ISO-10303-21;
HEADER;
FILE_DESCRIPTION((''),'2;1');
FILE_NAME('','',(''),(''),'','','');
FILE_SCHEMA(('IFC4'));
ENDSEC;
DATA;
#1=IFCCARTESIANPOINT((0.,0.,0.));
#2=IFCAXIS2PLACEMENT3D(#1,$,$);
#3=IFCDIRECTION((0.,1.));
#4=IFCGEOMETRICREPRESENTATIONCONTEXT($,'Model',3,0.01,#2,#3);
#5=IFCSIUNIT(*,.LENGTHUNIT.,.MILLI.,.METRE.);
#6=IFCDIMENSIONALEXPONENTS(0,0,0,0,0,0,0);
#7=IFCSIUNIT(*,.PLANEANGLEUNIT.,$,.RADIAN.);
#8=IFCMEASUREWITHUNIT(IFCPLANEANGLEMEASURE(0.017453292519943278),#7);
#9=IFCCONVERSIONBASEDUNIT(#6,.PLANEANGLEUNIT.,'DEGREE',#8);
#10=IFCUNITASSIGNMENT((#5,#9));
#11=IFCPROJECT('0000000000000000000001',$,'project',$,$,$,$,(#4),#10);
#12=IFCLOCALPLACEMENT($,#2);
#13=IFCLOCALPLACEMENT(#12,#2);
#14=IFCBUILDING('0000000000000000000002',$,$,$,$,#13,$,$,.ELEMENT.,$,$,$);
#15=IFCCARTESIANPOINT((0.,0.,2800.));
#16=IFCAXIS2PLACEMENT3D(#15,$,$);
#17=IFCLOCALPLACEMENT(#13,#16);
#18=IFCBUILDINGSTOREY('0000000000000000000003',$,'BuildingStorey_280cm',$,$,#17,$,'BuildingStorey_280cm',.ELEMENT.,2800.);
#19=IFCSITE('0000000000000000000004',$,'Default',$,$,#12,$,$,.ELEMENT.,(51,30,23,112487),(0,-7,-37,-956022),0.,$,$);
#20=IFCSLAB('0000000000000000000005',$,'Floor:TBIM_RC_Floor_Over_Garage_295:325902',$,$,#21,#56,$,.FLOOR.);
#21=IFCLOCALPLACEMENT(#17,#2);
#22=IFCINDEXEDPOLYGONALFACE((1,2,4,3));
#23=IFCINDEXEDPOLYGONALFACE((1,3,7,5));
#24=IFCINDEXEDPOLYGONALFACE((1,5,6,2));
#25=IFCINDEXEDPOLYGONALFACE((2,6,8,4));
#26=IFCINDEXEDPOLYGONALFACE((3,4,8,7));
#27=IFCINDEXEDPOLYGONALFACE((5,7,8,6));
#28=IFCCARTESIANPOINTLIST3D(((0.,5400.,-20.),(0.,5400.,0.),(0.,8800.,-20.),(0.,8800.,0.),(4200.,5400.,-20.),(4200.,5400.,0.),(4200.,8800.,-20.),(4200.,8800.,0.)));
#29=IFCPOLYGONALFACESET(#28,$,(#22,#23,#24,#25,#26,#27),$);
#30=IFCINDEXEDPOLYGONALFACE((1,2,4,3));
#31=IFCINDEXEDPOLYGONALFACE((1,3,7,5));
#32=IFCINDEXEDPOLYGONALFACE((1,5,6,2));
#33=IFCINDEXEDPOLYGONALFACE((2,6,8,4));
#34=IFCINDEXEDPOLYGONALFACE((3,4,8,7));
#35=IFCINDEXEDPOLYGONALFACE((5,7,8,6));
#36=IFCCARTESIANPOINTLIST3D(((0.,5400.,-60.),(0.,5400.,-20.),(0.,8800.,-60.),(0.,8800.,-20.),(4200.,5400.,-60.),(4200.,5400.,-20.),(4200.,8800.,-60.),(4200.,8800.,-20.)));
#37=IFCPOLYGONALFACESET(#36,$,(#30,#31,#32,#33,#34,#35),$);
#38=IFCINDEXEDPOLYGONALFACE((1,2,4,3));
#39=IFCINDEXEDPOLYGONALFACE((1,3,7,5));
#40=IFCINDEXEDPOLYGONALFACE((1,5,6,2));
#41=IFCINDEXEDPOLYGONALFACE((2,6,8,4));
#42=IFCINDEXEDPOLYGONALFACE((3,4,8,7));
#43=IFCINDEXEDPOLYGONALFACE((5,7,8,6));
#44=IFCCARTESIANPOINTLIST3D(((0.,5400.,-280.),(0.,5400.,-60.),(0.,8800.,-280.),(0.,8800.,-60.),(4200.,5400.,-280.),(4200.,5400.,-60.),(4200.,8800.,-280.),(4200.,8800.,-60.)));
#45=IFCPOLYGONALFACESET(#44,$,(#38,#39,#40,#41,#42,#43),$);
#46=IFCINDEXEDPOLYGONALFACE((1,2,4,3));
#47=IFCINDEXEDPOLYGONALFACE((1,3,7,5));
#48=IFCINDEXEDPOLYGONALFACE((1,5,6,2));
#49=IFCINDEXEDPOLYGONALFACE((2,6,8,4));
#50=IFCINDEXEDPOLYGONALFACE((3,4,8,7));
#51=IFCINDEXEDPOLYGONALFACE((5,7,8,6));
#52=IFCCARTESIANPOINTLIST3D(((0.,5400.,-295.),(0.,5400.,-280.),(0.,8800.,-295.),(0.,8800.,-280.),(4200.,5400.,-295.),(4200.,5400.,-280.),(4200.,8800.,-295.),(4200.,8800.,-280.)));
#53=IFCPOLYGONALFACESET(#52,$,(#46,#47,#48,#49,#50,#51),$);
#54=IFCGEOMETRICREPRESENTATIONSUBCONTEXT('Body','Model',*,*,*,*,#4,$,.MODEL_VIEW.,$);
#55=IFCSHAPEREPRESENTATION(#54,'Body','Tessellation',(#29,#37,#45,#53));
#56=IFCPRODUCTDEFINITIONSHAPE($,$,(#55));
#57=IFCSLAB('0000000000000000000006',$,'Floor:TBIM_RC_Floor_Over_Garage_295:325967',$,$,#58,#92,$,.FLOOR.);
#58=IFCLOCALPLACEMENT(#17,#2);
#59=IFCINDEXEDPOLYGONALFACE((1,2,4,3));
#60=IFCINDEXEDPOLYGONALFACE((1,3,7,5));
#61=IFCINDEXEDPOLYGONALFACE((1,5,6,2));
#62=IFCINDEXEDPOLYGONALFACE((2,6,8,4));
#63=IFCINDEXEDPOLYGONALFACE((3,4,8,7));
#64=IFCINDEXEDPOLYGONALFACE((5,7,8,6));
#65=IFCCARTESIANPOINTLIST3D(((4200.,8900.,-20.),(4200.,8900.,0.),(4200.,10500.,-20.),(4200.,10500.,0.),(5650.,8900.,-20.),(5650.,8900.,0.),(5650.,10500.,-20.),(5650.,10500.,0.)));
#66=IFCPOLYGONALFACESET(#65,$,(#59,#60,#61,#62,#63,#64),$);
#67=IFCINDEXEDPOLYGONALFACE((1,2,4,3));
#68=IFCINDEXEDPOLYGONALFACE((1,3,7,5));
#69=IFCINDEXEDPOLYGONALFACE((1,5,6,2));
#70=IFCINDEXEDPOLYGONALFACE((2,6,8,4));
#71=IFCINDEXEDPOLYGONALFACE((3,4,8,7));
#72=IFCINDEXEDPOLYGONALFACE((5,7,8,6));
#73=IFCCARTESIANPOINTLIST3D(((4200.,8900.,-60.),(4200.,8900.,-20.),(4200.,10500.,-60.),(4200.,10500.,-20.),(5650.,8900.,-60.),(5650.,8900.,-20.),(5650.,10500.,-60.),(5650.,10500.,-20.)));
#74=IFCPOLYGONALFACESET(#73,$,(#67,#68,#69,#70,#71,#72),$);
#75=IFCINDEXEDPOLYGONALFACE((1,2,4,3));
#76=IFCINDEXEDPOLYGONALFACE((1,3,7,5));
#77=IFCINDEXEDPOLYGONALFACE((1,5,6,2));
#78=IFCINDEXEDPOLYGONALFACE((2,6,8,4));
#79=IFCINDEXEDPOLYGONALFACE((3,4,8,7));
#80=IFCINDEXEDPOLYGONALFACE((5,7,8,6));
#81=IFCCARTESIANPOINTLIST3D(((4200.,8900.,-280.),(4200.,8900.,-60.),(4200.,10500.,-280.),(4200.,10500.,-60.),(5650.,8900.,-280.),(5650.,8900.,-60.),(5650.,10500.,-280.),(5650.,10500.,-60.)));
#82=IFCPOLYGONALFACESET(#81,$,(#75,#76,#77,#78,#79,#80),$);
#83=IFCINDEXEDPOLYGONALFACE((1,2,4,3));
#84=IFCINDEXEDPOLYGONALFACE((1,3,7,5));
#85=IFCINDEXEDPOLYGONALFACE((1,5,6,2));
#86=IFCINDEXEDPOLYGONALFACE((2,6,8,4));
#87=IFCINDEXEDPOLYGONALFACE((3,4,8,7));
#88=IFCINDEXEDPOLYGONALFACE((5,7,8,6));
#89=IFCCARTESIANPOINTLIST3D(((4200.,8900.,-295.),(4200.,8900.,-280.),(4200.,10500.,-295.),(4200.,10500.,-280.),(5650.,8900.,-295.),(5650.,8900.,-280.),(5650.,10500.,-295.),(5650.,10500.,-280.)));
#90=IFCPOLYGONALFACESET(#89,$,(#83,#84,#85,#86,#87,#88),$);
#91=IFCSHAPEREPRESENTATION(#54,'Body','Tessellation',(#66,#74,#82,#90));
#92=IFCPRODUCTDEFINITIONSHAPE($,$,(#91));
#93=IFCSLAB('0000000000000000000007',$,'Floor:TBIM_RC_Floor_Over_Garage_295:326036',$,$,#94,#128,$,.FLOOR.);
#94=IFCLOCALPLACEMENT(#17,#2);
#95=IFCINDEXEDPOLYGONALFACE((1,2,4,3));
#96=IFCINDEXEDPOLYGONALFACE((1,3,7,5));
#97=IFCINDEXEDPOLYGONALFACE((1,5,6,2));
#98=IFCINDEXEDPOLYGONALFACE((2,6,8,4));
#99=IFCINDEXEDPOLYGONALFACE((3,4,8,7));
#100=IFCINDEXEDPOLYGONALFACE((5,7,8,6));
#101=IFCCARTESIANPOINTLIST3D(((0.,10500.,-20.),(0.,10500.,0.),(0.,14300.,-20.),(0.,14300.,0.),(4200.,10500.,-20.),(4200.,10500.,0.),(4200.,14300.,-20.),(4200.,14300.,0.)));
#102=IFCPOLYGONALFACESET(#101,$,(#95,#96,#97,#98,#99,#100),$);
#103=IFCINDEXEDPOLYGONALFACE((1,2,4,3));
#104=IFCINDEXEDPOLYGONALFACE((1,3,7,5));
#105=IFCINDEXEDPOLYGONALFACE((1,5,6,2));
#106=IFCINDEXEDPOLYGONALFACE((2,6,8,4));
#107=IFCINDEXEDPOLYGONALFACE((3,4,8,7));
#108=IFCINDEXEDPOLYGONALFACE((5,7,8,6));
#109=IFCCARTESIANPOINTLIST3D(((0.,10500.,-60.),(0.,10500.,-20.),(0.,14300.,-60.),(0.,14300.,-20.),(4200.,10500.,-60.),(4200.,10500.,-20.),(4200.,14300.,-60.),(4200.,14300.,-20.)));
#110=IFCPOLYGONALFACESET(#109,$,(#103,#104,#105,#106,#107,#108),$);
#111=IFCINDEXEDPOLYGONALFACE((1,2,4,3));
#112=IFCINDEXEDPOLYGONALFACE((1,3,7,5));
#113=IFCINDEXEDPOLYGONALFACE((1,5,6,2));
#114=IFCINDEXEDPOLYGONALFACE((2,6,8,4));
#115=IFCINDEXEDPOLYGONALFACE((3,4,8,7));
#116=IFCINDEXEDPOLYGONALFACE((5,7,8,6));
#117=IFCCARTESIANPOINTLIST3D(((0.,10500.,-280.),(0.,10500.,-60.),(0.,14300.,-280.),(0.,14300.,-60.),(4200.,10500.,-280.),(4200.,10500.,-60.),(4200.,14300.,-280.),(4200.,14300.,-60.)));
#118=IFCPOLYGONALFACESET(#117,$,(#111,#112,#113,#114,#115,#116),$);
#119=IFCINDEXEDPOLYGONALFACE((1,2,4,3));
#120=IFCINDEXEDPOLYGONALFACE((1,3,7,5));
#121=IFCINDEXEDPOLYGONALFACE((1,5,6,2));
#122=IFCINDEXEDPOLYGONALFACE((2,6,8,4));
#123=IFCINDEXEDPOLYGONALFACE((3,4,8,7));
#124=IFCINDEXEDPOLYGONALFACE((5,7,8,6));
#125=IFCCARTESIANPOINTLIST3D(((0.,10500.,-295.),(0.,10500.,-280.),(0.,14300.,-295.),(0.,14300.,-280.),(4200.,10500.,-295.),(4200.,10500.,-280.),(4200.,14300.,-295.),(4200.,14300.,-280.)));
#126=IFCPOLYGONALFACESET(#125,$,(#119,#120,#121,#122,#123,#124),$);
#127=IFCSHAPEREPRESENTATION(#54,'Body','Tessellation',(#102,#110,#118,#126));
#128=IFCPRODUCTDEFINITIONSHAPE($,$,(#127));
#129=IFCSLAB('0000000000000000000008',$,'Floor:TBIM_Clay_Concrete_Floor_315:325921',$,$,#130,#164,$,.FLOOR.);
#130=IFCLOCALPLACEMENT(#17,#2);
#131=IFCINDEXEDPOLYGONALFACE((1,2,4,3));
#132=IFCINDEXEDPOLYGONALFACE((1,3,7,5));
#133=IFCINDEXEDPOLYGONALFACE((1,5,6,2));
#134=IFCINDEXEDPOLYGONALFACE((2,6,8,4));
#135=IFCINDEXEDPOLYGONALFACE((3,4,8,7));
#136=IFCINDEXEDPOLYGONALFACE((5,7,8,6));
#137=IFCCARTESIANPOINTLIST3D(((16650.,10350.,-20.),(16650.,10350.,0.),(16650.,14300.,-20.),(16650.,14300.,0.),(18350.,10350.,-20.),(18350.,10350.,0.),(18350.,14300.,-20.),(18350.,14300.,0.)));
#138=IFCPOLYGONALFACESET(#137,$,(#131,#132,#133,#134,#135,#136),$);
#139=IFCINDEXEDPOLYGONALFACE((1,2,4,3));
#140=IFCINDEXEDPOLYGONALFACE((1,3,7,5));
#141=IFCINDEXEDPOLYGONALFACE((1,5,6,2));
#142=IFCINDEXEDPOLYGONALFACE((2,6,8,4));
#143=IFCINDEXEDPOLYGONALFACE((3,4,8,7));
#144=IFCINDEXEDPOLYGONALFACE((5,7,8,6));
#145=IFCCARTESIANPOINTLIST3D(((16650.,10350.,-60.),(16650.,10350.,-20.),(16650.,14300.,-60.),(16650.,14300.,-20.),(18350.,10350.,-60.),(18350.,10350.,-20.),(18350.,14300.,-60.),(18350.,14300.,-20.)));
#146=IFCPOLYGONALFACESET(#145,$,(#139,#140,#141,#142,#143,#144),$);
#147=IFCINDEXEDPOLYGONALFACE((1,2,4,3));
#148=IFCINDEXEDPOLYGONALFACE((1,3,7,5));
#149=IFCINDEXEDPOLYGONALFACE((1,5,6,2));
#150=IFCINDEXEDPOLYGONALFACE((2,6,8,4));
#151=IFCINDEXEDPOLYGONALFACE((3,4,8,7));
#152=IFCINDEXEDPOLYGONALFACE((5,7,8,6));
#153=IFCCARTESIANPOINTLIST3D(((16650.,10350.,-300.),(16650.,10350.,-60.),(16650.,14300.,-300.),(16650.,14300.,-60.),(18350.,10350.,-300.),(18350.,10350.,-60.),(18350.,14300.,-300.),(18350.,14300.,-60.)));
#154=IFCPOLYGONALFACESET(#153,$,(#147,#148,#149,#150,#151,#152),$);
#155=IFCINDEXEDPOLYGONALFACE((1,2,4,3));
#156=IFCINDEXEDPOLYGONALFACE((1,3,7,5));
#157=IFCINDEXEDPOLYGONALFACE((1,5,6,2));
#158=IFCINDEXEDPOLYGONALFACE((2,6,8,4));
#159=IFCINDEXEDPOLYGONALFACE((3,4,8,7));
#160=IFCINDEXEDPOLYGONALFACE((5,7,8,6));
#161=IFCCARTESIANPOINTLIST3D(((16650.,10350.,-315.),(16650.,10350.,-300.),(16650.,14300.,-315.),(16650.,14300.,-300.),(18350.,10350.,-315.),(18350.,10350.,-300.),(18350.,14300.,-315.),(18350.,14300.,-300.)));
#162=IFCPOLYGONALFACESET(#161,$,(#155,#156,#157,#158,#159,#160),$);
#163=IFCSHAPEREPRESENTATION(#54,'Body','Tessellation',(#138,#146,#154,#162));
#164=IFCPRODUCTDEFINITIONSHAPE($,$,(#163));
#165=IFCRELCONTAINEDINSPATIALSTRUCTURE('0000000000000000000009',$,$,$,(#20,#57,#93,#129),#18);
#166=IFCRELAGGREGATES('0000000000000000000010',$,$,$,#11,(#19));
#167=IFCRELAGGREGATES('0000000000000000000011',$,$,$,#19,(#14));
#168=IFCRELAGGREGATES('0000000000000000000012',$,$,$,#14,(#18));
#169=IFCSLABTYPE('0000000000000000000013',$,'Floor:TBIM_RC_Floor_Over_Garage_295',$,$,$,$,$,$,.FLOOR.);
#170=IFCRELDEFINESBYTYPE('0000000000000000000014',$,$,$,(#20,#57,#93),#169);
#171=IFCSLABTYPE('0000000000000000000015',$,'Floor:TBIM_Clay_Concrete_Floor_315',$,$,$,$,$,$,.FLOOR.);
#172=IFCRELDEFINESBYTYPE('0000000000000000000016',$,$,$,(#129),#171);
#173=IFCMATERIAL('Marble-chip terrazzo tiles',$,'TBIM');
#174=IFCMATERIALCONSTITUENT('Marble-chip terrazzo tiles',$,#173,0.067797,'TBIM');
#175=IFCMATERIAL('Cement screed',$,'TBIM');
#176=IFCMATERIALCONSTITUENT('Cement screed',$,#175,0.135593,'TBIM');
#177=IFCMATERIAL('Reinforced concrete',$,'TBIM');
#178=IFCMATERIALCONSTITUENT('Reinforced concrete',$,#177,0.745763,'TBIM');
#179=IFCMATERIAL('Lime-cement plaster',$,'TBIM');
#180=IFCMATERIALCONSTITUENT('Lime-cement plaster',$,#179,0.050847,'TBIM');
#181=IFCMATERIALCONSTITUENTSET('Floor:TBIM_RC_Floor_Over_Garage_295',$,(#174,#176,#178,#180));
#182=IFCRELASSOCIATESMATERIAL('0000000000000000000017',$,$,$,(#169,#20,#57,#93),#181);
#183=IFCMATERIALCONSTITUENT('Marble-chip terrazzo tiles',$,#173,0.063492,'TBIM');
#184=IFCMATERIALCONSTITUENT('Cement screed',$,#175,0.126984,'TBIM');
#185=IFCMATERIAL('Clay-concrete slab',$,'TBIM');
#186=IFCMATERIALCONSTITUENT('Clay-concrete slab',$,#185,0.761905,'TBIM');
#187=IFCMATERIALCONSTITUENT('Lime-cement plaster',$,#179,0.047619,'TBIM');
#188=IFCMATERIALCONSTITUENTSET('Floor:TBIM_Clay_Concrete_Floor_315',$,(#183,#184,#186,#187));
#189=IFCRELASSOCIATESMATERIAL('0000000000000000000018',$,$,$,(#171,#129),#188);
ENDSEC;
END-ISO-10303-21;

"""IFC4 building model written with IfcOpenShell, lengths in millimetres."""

from ifc_helpers import new_model, entity, si_unit, converted_unit, direction, frame, origin, place, context, subcontext, project, spatial, indexed_curve, outline, extrude, material, constituent, constituent_set, type_object, element, save


model = new_model("IFC4")

# Units and contexts
model_context = context("Model", 3, precision=0.01, world=origin(), true_north=direction((0.0, 1.0)))
body_context = subcontext(model_context, "Body", "Model", "MODEL_VIEW")
ifc_project = project(units=[si_unit("LENGTHUNIT", "METRE", prefix="MILLI"), converted_unit("PLANEANGLEUNIT", "DEGREE", entity("IfcPlaneAngleMeasure", 0.017453292519943278), si_unit("PLANEANGLEUNIT", "RADIAN"), dimensions=[0, 0, 0, 0, 0, 0, 0])], contexts=[model_context])

# Site, building, storey
site_placement = place(None, origin())
site = spatial("IfcSite", under=ifc_project, at=site_placement, Name="Default", CompositionType="ELEMENT", RefLatitude=(51, 30, 23, 112487), RefLongitude=(0, -7, -37, -956022), RefElevation=0.0)
building_placement = place(site_placement, origin())
building = spatial("IfcBuilding", under=site, at=building_placement, CompositionType="ELEMENT")
storey_placement = place(building_placement, frame((0.0, 0.0, 2800.0)))
storey = spatial("IfcBuildingStorey", under=building, at=storey_placement, Name="BuildingStorey_280cm", LongName="BuildingStorey_280cm", CompositionType="ELEMENT", Elevation=2800.0)

# Slabs
ifc_material_1 = material(Name="Marble-chip terrazzo tiles", Category="TBIM")
ifc_constituent_1 = constituent(ifc_material_1, Name="Marble-chip terrazzo tiles", Category="TBIM", fraction=0.067797)
ifc_material_2 = material(Name="Cement screed", Category="TBIM")
ifc_constituent_2 = constituent(ifc_material_2, Name="Cement screed", Category="TBIM", fraction=0.135593)
ifc_material_3 = material(Name="Reinforced concrete", Category="TBIM")
ifc_constituent_3 = constituent(ifc_material_3, Name="Reinforced concrete", Category="TBIM", fraction=0.745763)
ifc_material_4 = material(Name="Lime-cement plaster", Category="TBIM")
ifc_constituent_4 = constituent(ifc_material_4, Name="Lime-cement plaster", Category="TBIM", fraction=0.050847)
ifc_constituent_set_1 = constituent_set(constituents=[ifc_constituent_1, ifc_constituent_2, ifc_constituent_3, ifc_constituent_4], Name="Floor:TBIM_RC_Floor_Over_Garage_295")
slab_type_1 = type_object("IfcSlabType", Name="Floor:TBIM_RC_Floor_Over_Garage_295", PredefinedType="FLOOR", material=ifc_constituent_set_1)
slab_1_placement = place(storey_placement, origin())
element("IfcSlab", 1, at=slab_1_placement, inside=storey, type_object=slab_type_1, material=ifc_constituent_set_1, Name="Floor:TBIM_RC_Floor_Over_Garage_295:325902", PredefinedType="FLOOR", context=body_context, shape_type="SweptSolid", body=[
    extrude(outline(indexed_curve([(-2100.0, -1700.0), (2100.0, -1700.0), (2100.0, 1700.0), (-2100.0, 1700.0), (-2100.0, -1700.0)], self_intersect=False)), frame((2100.0, 7100.0, -20.0), z_axis=(0.0, 0.0, 1.0), x_axis=(-1.0, 0.0, 0.0)), (0.0, 0.0, 1.0), 20.0),
    extrude(outline(indexed_curve([(-2100.0, -1700.0), (2100.0, -1700.0), (2100.0, 1700.0), (-2100.0, 1700.0), (-2100.0, -1700.0)], self_intersect=False)), frame((2100.0, 7100.0, -60.0), z_axis=(0.0, 0.0, 1.0), x_axis=(-1.0, 0.0, 0.0)), (0.0, 0.0, 1.0), 40.0),
    extrude(outline(indexed_curve([(-2100.0, -1700.0), (2100.0, -1700.0), (2100.0, 1700.0), (-2100.0, 1700.0), (-2100.0, -1700.0)], self_intersect=False)), frame((2100.0, 7100.0, -280.0), z_axis=(0.0, 0.0, 1.0), x_axis=(-1.0, 0.0, 0.0)), (0.0, 0.0, 1.0), 220.0),
    extrude(outline(indexed_curve([(-2100.0, -1700.0), (2100.0, -1700.0), (2100.0, 1700.0), (-2100.0, 1700.0), (-2100.0, -1700.0)], self_intersect=False)), frame((2100.0, 7100.0, -295.0), z_axis=(0.0, 0.0, 1.0), x_axis=(-1.0, 0.0, 0.0)), (0.0, 0.0, 1.0), 15.0),
])
slab_2_placement = place(storey_placement, origin())
element("IfcSlab", 2, at=slab_2_placement, inside=storey, type_object=slab_type_1, material=ifc_constituent_set_1, Name="Floor:TBIM_RC_Floor_Over_Garage_295:325967", PredefinedType="FLOOR", context=body_context, shape_type="SweptSolid", body=[
    extrude(outline(indexed_curve([(-725.0, -800.0), (725.0, -800.0), (725.0, 800.0), (-725.0, 800.0), (-725.0, -800.0)], self_intersect=False)), frame((4925.0, 9700.0, -20.0), z_axis=(0.0, 0.0, 1.0), x_axis=(-1.0, 0.0, 0.0)), (0.0, 0.0, 1.0), 20.0),
    extrude(outline(indexed_curve([(-725.0, -800.0), (725.0, -800.0), (725.0, 800.0), (-725.0, 800.0), (-725.0, -800.0)], self_intersect=False)), frame((4925.0, 9700.0, -60.0), z_axis=(0.0, 0.0, 1.0), x_axis=(-1.0, 0.0, 0.0)), (0.0, 0.0, 1.0), 40.0),
    extrude(outline(indexed_curve([(-725.0, -800.0), (725.0, -800.0), (725.0, 800.0), (-725.0, 800.0), (-725.0, -800.0)], self_intersect=False)), frame((4925.0, 9700.0, -280.0), z_axis=(0.0, 0.0, 1.0), x_axis=(-1.0, 0.0, 0.0)), (0.0, 0.0, 1.0), 220.0),
    extrude(outline(indexed_curve([(-725.0, -800.0), (725.0, -800.0), (725.0, 800.0), (-725.0, 800.0), (-725.0, -800.0)], self_intersect=False)), frame((4925.0, 9700.0, -295.0), z_axis=(0.0, 0.0, 1.0), x_axis=(-1.0, 0.0, 0.0)), (0.0, 0.0, 1.0), 15.0),
])
slab_3_placement = place(storey_placement, origin())
element("IfcSlab", 3, at=slab_3_placement, inside=storey, type_object=slab_type_1, material=ifc_constituent_set_1, Name="Floor:TBIM_RC_Floor_Over_Garage_295:326036", PredefinedType="FLOOR", context=body_context, shape_type="SweptSolid", body=[
    extrude(outline(indexed_curve([(-1900.0, -2100.0), (1900.0, -2100.0), (1900.0, 2100.0), (-1900.0, 2100.0), (-1900.0, -2100.0)], self_intersect=False)), frame((2100.0, 12400.0, -20.0), z_axis=(0.0, 0.0, 1.0), x_axis=(0.0, -1.0, 0.0)), (0.0, 0.0, 1.0), 20.0),
    extrude(outline(indexed_curve([(-1900.0, -2100.0), (1900.0, -2100.0), (1900.0, 2100.0), (-1900.0, 2100.0), (-1900.0, -2100.0)], self_intersect=False)), frame((2100.0, 12400.0, -60.0), z_axis=(0.0, 0.0, 1.0), x_axis=(0.0, -1.0, 0.0)), (0.0, 0.0, 1.0), 40.0),
    extrude(outline(indexed_curve([(-1900.0, -2100.0), (1900.0, -2100.0), (1900.0, 2100.0), (-1900.0, 2100.0), (-1900.0, -2100.0)], self_intersect=False)), frame((2100.0, 12400.0, -280.0), z_axis=(0.0, 0.0, 1.0), x_axis=(0.0, -1.0, 0.0)), (0.0, 0.0, 1.0), 220.0),
    extrude(outline(indexed_curve([(-1900.0, -2100.0), (1900.0, -2100.0), (1900.0, 2100.0), (-1900.0, 2100.0), (-1900.0, -2100.0)], self_intersect=False)), frame((2100.0, 12400.0, -295.0), z_axis=(0.0, 0.0, 1.0), x_axis=(0.0, -1.0, 0.0)), (0.0, 0.0, 1.0), 15.0),
])
ifc_constituent_5 = constituent(ifc_material_1, Name="Marble-chip terrazzo tiles", Category="TBIM", fraction=0.063492)
ifc_constituent_6 = constituent(ifc_material_2, Name="Cement screed", Category="TBIM", fraction=0.126984)
ifc_material_5 = material(Name="Clay-concrete slab", Category="TBIM")
ifc_constituent_7 = constituent(ifc_material_5, Name="Clay-concrete slab", Category="TBIM", fraction=0.761905)
ifc_constituent_8 = constituent(ifc_material_4, Name="Lime-cement plaster", Category="TBIM", fraction=0.047619)
ifc_constituent_set_2 = constituent_set(constituents=[ifc_constituent_5, ifc_constituent_6, ifc_constituent_7, ifc_constituent_8], Name="Floor:TBIM_Clay_Concrete_Floor_315")
slab_type_2 = type_object("IfcSlabType", Name="Floor:TBIM_Clay_Concrete_Floor_315", PredefinedType="FLOOR", material=ifc_constituent_set_2)
slab_4_placement = place(storey_placement, origin())
element("IfcSlab", 4, at=slab_4_placement, inside=storey, type_object=slab_type_2, material=ifc_constituent_set_2, Name="Floor:TBIM_Clay_Concrete_Floor_315:325921", PredefinedType="FLOOR", context=body_context, shape_type="SweptSolid", body=[
    extrude(outline(indexed_curve([(-850.0, -1975.0), (850.0, -1975.0), (850.0, 1975.0), (-850.0, 1975.0), (-850.0, -1975.0)], self_intersect=False)), frame((17500.0, 12325.0, -20.0), z_axis=(0.0, 0.0, 1.0), x_axis=(-1.0, 0.0, 0.0)), (0.0, 0.0, 1.0), 20.0),
    extrude(outline(indexed_curve([(-850.0, -1975.0), (850.0, -1975.0), (850.0, 1975.0), (-850.0, 1975.0), (-850.0, -1975.0)], self_intersect=False)), frame((17500.0, 12325.0, -60.0), z_axis=(0.0, 0.0, 1.0), x_axis=(-1.0, 0.0, 0.0)), (0.0, 0.0, 1.0), 40.0),
    extrude(outline(indexed_curve([(-850.0, -1975.0), (850.0, -1975.0), (850.0, 1975.0), (-850.0, 1975.0), (-850.0, -1975.0)], self_intersect=False)), frame((17500.0, 12325.0, -300.0), z_axis=(0.0, 0.0, 1.0), x_axis=(-1.0, 0.0, 0.0)), (0.0, 0.0, 1.0), 240.0),
    extrude(outline(indexed_curve([(-850.0, -1975.0), (850.0, -1975.0), (850.0, 1975.0), (-850.0, 1975.0), (-850.0, -1975.0)], self_intersect=False)), frame((17500.0, 12325.0, -315.0), z_axis=(0.0, 0.0, 1.0), x_axis=(-1.0, 0.0, 0.0)), (0.0, 0.0, 1.0), 15.0),
])

save(model, "model.ifc")
